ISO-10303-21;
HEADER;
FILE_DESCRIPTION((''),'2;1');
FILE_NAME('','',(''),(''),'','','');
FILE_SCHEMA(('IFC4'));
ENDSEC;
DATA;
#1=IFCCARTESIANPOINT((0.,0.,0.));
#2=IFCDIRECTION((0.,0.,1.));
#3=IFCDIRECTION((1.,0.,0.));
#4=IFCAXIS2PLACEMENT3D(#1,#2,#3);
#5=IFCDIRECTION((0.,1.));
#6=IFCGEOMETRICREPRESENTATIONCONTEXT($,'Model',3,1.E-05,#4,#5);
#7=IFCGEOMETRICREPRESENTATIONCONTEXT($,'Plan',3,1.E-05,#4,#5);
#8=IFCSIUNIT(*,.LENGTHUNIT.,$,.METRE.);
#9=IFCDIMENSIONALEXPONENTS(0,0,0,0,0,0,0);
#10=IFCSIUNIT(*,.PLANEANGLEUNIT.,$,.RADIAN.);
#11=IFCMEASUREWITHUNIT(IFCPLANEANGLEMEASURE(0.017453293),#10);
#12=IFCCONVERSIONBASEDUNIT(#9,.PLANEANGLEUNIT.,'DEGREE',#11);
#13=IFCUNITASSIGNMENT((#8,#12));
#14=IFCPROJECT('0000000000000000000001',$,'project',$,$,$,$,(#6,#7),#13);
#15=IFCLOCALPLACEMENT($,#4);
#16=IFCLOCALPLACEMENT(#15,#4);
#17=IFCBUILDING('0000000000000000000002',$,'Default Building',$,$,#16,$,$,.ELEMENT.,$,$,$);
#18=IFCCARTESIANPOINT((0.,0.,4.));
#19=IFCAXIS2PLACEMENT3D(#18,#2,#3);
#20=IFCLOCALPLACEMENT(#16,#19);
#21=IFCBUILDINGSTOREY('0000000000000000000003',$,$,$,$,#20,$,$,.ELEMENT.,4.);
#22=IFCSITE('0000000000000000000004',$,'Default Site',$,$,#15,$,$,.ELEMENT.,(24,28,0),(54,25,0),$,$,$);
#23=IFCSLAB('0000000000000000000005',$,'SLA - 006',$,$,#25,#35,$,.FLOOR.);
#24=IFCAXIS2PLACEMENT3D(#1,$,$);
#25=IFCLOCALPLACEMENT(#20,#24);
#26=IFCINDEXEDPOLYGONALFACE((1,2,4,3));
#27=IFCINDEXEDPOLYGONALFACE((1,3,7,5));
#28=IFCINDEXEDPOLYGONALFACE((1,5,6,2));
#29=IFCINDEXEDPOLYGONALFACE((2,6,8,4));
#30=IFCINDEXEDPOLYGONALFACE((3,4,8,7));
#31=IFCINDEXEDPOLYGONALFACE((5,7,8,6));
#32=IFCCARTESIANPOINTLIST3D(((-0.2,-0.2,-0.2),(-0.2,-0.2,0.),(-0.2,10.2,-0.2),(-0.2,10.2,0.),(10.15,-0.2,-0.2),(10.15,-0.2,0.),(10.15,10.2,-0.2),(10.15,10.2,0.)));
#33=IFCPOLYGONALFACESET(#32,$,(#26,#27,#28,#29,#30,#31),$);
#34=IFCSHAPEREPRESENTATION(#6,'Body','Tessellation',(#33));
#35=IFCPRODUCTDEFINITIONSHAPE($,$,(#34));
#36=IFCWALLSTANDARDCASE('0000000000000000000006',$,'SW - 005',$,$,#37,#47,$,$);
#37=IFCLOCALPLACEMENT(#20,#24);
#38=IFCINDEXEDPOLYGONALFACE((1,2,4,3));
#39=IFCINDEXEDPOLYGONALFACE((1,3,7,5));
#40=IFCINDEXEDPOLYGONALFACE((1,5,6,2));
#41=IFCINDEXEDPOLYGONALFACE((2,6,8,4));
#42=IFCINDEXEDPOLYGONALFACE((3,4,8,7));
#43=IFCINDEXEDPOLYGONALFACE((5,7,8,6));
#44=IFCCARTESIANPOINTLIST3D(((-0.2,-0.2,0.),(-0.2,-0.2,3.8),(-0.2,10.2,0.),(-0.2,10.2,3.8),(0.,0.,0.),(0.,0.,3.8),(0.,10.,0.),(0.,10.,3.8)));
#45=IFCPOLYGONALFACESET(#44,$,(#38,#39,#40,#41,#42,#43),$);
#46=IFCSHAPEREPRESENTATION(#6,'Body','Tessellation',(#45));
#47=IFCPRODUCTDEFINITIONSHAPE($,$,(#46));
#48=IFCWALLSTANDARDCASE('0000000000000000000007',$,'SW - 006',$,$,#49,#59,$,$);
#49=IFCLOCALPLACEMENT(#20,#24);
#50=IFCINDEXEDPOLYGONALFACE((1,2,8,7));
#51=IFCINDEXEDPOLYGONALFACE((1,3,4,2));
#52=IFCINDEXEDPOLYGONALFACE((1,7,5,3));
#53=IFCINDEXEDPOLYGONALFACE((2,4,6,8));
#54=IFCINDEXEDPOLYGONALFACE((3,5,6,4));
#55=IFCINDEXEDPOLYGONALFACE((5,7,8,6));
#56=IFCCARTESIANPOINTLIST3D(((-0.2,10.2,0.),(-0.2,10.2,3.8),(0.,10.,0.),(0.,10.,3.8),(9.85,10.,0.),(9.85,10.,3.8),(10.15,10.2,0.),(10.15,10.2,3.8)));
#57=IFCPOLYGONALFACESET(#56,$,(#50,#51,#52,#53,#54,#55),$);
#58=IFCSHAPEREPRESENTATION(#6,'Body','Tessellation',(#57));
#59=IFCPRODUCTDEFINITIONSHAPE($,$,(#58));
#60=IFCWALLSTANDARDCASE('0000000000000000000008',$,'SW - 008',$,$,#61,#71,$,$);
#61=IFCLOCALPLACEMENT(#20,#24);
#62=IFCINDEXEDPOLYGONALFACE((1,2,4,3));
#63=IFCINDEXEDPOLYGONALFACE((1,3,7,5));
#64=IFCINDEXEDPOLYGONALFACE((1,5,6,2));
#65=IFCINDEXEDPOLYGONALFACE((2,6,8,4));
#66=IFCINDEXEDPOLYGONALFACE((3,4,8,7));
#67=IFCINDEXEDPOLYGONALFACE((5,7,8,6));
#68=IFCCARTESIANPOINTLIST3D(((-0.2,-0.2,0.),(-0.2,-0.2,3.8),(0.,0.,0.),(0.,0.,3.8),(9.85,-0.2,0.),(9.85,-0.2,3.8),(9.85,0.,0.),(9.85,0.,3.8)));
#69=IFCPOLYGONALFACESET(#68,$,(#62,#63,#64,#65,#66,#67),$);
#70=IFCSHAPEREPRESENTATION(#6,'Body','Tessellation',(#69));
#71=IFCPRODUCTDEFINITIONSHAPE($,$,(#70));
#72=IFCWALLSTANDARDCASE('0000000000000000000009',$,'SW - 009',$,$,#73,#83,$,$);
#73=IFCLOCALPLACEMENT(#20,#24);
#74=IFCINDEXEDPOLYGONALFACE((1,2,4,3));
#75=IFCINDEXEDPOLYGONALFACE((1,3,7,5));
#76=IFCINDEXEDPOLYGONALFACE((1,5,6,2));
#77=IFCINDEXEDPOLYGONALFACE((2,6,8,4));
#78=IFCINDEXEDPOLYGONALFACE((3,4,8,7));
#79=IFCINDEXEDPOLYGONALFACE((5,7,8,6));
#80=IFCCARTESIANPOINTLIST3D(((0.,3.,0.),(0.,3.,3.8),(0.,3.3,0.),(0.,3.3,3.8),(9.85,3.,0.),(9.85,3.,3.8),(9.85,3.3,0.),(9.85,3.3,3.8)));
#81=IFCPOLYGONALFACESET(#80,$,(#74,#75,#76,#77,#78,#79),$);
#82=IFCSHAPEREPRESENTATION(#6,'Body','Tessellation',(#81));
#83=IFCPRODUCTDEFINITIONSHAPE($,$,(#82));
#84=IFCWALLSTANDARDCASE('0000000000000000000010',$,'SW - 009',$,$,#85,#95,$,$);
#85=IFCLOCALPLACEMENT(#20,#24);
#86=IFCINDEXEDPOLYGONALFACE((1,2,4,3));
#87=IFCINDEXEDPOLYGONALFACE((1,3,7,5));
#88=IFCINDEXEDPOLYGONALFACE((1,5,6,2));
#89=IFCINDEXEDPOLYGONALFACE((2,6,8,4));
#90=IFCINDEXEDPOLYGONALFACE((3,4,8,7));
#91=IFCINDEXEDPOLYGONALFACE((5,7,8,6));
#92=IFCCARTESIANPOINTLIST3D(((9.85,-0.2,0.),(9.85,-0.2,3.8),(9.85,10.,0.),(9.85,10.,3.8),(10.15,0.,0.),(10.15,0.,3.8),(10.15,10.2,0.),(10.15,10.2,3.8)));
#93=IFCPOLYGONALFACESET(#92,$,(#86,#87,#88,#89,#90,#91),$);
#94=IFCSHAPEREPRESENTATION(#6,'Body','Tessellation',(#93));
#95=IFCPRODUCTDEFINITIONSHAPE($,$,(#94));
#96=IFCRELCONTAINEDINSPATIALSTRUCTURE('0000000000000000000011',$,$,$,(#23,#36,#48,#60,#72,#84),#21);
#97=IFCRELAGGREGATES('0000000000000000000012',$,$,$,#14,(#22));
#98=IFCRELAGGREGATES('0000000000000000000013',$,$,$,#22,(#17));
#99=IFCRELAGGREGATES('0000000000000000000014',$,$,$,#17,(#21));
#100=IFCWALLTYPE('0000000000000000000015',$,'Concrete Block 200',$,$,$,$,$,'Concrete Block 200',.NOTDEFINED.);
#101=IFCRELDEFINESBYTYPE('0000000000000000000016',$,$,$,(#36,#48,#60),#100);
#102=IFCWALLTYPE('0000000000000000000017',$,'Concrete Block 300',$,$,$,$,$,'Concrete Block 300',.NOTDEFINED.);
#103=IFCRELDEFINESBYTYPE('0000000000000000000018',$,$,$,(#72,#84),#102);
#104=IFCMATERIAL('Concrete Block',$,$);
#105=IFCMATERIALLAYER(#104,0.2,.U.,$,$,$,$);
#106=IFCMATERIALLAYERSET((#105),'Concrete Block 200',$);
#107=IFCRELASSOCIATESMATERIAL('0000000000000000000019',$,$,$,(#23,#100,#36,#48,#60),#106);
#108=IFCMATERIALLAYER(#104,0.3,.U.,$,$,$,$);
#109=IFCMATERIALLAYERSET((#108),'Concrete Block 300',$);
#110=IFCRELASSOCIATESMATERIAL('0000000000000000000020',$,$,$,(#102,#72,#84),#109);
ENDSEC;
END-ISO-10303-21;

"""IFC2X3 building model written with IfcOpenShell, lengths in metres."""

from ifc_helpers import new_model, entity, si_unit, converted_unit, direction, frame, origin_with_axes, place, context, project, spatial, polyline, outline, extrude, material, layer, layer_set, layer_usage, type_object, element, save


model = new_model("IFC2X3")

# Units and contexts
model_context = context("Model", 3, precision=1e-05, world=origin_with_axes(), true_north=direction((0.0, 1.0)))
plan_context = context("Plan", 3, precision=1e-05, world=origin_with_axes(), true_north=direction((0.0, 1.0)))
ifc_project = project(units=[si_unit("LENGTHUNIT", "METRE"), converted_unit("PLANEANGLEUNIT", "DEGREE", entity("IfcPlaneAngleMeasure", 0.017453293), si_unit("PLANEANGLEUNIT", "RADIAN"), dimensions=[0, 0, 0, 0, 0, 0, 0])], contexts=[model_context, plan_context])

# Site, building, storey
site_placement = place(None, origin_with_axes())
site = spatial("IfcSite", under=ifc_project, at=site_placement, Name="Default Site", CompositionType="ELEMENT", RefLatitude=(24, 28, 0), RefLongitude=(54, 25, 0))
building_placement = place(site_placement, origin_with_axes())
building = spatial("IfcBuilding", under=site, at=building_placement, Name="Default Building", CompositionType="ELEMENT")
storey_placement = place(building_placement, frame((0.0, 0.0, 4.0), z_axis=(0.0, 0.0, 1.0), x_axis=(1.0, 0.0, 0.0)))
storey = spatial("IfcBuildingStorey", under=building, at=storey_placement, CompositionType="ELEMENT", Elevation=4.0)

# Slab
ifc_material = material(Name="Concrete Block")
ifc_layer_1 = layer(ifc_material, 0.2, ventilated="UNKNOWN")
ifc_layer_set_1 = layer_set([ifc_layer_1], Name="Concrete Block 200")
ifc_layer_usage_1 = layer_usage(ifc_layer_set_1, "AXIS3", "NEGATIVE", 0.2)
slab_placement = place(storey_placement, frame((-0.2, 10.2, -0.2), z_axis=(0.0, 0.0, 1.0), x_axis=(0.0, -1.0, 0.0)))
element("IfcSlab", 1, at=slab_placement, inside=storey, material=ifc_layer_usage_1, Name="SLA - 006", PredefinedType="FLOOR", context=model_context, shape_type="SweptSolid", body=[
    extrude(outline(polyline([(0.0, 0.0), (10.4, 0.0), (10.4, 10.35), (0.0, 10.35), (0.0, 0.0)])), origin_with_axes(), (0.0, 0.0, 1.0), 0.2),
])

# Walls
ifc_layer_usage_2 = layer_usage(ifc_layer_set_1, "AXIS2", "POSITIVE", 0.0)
wall_type_1 = type_object("IfcWallType", Name="Concrete Block 200", ElementType="Concrete Block 200", PredefinedType="NOTDEFINED", material=ifc_layer_set_1)
wall_1_placement = place(storey_placement, frame((0.0, 0.0, 0.0), z_axis=(0.0, 0.0, 1.0), x_axis=(0.0, 1.0, 0.0)))
element("IfcWallStandardCase", 2, at=wall_1_placement, inside=storey, type_object=wall_type_1, material=ifc_layer_usage_2, Name="SW - 005", context=model_context, shape_type="SweptSolid", body=[
    extrude(outline(polyline([(0.0, 0.0), (10.0, 0.0), (10.2, 0.2), (-0.2, 0.2), (0.0, 0.0)])), origin_with_axes(), (0.0, 0.0, 1.0), 3.8),
])
ifc_layer_usage_3 = layer_usage(ifc_layer_set_1, "AXIS2", "POSITIVE", 0.0)
wall_2_placement = place(storey_placement, frame((0.0, 10.0, 0.0), z_axis=(0.0, 0.0, 1.0), x_axis=(1.0, 0.0, 0.0)))
element("IfcWallStandardCase", 3, at=wall_2_placement, inside=storey, type_object=wall_type_1, material=ifc_layer_usage_3, Name="SW - 006", context=model_context, shape_type="SweptSolid", body=[
    extrude(outline(polyline([(0.0, 0.0), (9.85, 0.0), (10.15, 0.2), (-0.2, 0.2), (0.0, 0.0)])), origin_with_axes(), (0.0, 0.0, 1.0), 3.8),
])
ifc_layer_usage_4 = layer_usage(ifc_layer_set_1, "AXIS2", "POSITIVE", 0.0)
wall_3_placement = place(storey_placement, frame((9.85, 0.0, 0.0), z_axis=(0.0, 0.0, 1.0), x_axis=(-1.0, 0.0, 0.0)))
element("IfcWallStandardCase", 4, at=wall_3_placement, inside=storey, type_object=wall_type_1, material=ifc_layer_usage_4, Name="SW - 008", context=model_context, shape_type="SweptSolid", body=[
    extrude(outline(polyline([(0.0, 0.0), (9.85, 0.0), (10.05, 0.2), (0.0, 0.2), (0.0, 0.0)])), origin_with_axes(), (0.0, 0.0, 1.0), 3.8),
])
ifc_layer_2 = layer(ifc_material, 0.3, ventilated="UNKNOWN")
ifc_layer_set_2 = layer_set([ifc_layer_2], Name="Concrete Block 300")
ifc_layer_usage_5 = layer_usage(ifc_layer_set_2, "AXIS2", "POSITIVE", -0.15)
wall_type_2 = type_object("IfcWallType", Name="Concrete Block 300", ElementType="Concrete Block 300", PredefinedType="NOTDEFINED", material=ifc_layer_set_2)
wall_4_placement = place(storey_placement, frame((10.15, 3.15, 0.0), z_axis=(0.0, 0.0, 1.0), x_axis=(-1.0, 0.0, 0.0)))
element("IfcWallStandardCase", 5, at=wall_4_placement, inside=storey, type_object=wall_type_2, material=ifc_layer_usage_5, Name="SW - 009", context=model_context, shape_type="SweptSolid", body=[
    extrude(outline(polyline([(0.3, -0.15), (10.15, -0.15), (10.15, 0.15), (0.3, 0.15), (0.3, -0.15)])), origin_with_axes(), (0.0, 0.0, 1.0), 3.8),
])
ifc_layer_usage_6 = layer_usage(ifc_layer_set_2, "AXIS2", "POSITIVE", 0.0)
wall_5_placement = place(storey_placement, frame((10.15, 0.0, 0.0), z_axis=(0.0, 0.0, 1.0), x_axis=(0.0, 1.0, 0.0)))
element("IfcWallStandardCase", 6, at=wall_5_placement, inside=storey, type_object=wall_type_2, material=ifc_layer_usage_6, Name="SW - 009", context=model_context, shape_type="SweptSolid", body=[
    extrude(outline(polyline([(0.0, 0.0), (10.2, 0.0), (10.0, 0.3), (-0.2, 0.3), (0.0, 0.0)])), origin_with_axes(), (0.0, 0.0, 1.0), 3.8),
])

save(model, "model.ifc")
